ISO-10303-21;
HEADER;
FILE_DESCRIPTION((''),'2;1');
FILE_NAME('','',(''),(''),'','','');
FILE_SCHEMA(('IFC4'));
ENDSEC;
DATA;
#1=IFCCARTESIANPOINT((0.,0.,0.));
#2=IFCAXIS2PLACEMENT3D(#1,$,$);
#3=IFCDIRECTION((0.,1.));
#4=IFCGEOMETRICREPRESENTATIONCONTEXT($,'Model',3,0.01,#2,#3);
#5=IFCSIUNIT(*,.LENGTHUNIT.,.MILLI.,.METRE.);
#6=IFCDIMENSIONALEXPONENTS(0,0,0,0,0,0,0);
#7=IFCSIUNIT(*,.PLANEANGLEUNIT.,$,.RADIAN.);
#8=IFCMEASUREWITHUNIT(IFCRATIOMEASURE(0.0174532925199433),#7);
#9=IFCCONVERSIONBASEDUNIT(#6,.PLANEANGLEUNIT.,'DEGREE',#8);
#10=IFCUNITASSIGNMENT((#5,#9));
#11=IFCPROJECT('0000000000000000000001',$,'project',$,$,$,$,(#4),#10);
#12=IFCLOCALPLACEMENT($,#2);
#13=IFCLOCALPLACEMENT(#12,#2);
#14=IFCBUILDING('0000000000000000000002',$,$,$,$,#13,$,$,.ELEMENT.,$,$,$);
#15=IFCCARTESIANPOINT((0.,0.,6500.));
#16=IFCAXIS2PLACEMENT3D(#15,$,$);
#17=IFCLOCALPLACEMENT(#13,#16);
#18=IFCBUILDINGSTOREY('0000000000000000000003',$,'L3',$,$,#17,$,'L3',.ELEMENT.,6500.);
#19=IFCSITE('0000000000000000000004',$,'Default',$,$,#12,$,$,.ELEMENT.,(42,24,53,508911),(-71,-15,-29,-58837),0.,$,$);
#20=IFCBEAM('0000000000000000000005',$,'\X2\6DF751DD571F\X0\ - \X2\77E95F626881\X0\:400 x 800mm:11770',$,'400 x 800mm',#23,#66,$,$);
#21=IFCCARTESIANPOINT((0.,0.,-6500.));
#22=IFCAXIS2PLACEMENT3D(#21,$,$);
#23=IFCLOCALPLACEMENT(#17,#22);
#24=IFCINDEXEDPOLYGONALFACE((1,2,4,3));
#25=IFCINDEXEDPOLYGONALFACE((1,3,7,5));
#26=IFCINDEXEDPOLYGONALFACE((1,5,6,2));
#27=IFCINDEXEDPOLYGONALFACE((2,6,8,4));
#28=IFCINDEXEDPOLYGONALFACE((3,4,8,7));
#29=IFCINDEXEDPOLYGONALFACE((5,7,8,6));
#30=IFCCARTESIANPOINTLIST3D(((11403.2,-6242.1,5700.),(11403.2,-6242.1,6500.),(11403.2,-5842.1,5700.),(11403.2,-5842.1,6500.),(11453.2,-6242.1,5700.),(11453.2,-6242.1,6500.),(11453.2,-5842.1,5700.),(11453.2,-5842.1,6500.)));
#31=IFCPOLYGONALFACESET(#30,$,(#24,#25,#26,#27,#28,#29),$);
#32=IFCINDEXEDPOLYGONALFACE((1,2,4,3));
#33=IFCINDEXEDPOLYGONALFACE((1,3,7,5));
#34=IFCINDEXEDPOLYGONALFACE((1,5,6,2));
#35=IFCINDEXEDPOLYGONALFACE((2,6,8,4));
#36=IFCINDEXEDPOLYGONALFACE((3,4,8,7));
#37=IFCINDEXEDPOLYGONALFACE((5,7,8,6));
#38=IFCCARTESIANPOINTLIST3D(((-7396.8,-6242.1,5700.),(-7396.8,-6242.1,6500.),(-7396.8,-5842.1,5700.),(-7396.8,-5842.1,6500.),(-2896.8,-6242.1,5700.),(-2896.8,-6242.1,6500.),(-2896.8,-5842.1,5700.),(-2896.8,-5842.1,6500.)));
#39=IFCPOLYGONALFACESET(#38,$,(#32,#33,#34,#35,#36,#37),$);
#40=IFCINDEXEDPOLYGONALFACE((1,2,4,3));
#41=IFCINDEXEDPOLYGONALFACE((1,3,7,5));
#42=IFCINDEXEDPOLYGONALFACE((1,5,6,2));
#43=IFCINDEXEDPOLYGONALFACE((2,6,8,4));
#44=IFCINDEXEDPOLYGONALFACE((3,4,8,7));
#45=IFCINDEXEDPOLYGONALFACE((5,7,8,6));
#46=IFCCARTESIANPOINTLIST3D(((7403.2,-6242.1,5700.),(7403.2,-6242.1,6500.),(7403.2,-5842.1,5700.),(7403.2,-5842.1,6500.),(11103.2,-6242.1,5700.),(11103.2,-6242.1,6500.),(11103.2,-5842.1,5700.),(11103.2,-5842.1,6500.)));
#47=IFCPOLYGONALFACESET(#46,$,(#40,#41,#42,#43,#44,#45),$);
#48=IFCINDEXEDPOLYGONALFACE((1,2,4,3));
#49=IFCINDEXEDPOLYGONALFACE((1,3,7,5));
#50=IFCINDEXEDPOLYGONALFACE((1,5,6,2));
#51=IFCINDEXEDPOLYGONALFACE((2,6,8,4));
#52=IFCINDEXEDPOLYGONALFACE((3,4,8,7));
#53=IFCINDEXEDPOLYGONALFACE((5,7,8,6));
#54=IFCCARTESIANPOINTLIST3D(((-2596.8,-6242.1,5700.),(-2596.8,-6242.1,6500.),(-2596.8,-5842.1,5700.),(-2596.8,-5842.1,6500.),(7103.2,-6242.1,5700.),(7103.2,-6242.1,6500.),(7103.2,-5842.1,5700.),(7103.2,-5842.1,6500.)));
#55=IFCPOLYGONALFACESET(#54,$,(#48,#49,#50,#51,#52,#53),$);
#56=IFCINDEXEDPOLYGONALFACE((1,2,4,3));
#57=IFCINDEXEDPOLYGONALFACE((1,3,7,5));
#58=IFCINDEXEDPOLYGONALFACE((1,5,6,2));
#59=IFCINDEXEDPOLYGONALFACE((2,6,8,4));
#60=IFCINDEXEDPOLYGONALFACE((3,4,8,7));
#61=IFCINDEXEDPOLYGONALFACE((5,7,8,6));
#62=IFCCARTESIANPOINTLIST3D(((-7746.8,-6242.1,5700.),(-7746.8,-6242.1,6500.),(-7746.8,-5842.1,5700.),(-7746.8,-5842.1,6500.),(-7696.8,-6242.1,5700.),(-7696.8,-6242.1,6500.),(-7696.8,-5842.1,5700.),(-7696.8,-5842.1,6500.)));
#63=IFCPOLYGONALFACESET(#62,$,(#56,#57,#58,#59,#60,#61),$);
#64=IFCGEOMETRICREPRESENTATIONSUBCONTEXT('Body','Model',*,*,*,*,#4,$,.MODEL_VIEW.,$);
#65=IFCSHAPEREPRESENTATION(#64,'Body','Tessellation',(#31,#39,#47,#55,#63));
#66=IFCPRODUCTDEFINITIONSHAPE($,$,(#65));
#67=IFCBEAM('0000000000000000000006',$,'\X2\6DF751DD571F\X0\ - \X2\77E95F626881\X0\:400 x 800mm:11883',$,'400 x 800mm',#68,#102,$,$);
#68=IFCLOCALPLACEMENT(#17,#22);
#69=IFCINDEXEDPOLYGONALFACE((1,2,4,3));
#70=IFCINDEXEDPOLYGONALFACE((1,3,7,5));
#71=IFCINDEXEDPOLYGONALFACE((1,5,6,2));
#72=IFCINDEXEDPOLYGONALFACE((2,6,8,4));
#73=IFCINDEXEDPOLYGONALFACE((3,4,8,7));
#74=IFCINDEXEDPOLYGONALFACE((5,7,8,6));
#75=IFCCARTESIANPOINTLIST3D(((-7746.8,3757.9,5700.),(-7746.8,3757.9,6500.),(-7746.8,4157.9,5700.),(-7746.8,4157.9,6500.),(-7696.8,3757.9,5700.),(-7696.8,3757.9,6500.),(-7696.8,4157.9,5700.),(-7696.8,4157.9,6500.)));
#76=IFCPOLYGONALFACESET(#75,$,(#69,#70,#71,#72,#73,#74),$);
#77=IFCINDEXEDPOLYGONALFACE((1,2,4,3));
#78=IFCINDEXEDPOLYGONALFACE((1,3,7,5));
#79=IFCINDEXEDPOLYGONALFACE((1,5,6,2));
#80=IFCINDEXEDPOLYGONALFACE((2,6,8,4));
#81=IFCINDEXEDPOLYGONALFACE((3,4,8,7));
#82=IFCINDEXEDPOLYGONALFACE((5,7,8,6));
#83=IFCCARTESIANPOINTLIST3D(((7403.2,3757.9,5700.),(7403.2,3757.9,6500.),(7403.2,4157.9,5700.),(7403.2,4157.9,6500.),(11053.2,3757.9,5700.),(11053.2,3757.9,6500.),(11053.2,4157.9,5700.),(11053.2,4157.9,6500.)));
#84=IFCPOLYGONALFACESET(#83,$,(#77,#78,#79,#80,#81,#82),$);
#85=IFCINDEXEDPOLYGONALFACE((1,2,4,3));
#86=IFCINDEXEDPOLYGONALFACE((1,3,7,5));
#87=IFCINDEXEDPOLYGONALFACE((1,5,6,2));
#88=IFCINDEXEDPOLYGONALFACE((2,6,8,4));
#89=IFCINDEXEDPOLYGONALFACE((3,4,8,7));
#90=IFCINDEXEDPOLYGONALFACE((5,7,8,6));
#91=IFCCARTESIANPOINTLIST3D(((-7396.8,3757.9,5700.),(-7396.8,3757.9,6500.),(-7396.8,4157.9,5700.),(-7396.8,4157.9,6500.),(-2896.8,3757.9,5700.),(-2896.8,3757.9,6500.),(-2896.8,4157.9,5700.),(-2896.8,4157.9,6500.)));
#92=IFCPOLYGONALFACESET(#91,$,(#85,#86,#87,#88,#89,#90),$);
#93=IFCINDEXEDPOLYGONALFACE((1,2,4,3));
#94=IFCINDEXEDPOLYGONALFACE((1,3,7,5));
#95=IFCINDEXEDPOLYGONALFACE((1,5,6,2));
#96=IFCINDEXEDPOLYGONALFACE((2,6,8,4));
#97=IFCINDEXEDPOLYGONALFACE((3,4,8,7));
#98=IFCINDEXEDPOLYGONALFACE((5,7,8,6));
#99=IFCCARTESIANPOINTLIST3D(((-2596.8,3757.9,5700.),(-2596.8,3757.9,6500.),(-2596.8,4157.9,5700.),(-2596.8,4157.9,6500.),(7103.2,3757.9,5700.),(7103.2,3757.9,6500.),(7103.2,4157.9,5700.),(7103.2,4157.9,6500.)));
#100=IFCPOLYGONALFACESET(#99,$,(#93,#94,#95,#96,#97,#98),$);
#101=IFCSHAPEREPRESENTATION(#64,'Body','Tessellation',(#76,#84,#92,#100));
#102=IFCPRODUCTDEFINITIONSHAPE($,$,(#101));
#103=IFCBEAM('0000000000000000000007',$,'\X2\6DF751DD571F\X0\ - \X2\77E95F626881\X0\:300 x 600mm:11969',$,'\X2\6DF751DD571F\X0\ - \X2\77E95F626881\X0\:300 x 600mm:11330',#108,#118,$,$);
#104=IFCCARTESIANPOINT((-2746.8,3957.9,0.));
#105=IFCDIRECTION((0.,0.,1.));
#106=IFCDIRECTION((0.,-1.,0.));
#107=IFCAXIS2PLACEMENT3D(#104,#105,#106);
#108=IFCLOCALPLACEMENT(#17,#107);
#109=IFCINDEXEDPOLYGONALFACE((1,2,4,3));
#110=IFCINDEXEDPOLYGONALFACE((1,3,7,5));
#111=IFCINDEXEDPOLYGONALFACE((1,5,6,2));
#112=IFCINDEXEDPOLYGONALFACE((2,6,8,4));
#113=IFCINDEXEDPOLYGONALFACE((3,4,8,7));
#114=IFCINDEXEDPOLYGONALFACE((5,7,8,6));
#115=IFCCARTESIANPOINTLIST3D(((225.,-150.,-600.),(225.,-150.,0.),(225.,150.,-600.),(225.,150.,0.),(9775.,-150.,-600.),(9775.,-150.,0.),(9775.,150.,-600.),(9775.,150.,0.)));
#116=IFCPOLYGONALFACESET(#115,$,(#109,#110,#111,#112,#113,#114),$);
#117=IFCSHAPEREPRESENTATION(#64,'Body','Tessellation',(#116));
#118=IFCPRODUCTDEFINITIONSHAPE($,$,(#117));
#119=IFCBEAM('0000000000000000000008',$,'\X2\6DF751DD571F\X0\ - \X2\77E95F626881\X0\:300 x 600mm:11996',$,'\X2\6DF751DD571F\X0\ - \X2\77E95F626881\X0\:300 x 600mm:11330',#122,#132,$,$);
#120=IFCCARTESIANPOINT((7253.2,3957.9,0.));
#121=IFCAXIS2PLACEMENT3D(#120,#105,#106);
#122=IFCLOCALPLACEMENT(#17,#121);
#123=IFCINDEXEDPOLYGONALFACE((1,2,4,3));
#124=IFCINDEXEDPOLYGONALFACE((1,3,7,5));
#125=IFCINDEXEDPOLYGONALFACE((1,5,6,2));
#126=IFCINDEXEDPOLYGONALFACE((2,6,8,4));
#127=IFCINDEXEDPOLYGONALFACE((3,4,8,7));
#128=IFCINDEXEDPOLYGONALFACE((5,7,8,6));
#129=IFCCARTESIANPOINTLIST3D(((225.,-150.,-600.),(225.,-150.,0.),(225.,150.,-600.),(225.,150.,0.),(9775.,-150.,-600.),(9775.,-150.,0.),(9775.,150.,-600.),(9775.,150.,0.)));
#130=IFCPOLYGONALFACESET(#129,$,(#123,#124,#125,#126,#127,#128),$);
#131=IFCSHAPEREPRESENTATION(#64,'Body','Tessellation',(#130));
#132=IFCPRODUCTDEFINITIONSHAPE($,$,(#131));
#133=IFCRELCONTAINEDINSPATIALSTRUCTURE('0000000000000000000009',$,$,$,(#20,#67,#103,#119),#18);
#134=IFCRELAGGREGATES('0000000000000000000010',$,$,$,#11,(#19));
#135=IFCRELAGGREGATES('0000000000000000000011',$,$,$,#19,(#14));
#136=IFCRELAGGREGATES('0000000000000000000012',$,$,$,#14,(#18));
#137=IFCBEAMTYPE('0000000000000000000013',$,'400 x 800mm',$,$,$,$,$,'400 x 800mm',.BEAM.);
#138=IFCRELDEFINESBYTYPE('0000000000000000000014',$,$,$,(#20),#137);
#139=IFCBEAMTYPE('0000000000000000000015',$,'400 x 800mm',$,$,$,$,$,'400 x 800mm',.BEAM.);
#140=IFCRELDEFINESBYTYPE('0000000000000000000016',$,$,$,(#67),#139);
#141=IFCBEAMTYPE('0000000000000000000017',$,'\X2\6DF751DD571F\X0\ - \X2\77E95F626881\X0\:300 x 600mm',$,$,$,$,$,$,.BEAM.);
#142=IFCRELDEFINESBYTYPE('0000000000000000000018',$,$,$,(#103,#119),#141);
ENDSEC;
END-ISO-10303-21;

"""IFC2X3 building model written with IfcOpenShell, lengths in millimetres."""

from ifc_helpers import new_model, entity, si_unit, converted_unit, direction, frame, frame_2d, origin, origin_2d_with_axis, place, context, subcontext, project, spatial, rectangle, extrude, source, transform, mapped, type_object, type_shapes, element, save


model = new_model("IFC2X3")

# Units and contexts
model_context = context("Model", 3, precision=0.01, world=origin(), true_north=direction((0.0, 1.0)))
body_context = subcontext(model_context, "Body", "Model", "MODEL_VIEW")
ifc_project = project(units=[si_unit("LENGTHUNIT", "METRE", prefix="MILLI"), converted_unit("PLANEANGLEUNIT", "DEGREE", entity("IfcRatioMeasure", 0.0174532925199433), si_unit("PLANEANGLEUNIT", "RADIAN"), dimensions=[0, 0, 0, 0, 0, 0, 0])], contexts=[model_context])

# Site, building, storey
site_placement = place(None, origin())
site = spatial("IfcSite", under=ifc_project, at=site_placement, Name="Default", CompositionType="ELEMENT", RefLatitude=(42, 24, 53, 508911), RefLongitude=(-71, -15, -29, -58837), RefElevation=0.0)
building_placement = place(site_placement, origin())
building = spatial("IfcBuilding", under=site, at=building_placement, CompositionType="ELEMENT")
storey_placement = place(building_placement, frame((0.0, 0.0, 6500.0)))
storey = spatial("IfcBuildingStorey", under=building, at=storey_placement, Name="L3", LongName="L3", CompositionType="ELEMENT", Elevation=6500.0)

# Beams
beam_type_1 = type_object("IfcBeamType", Name="400 x 800mm", ElementType="400 x 800mm", PredefinedType="BEAM")
shared_shape_1 = source(origin(), body_context, "Body", "SweptSolid", [
    extrude(rectangle(XDim=50.0, YDim=400.0, at=frame_2d((0.0, 0.0), x_axis=(1.0, 0.0))), frame((11428.2, -6042.1, 5700.0), z_axis=(0.0, 0.0, 1.0), x_axis=(-1.0, 0.0, 0.0)), (0.0, 0.0, 1.0), 800.0),
    extrude(rectangle(XDim=4500.0, YDim=400.0, at=frame_2d((440.0, -40.0), x_axis=(1.0, 0.0))), frame((-5586.8, -6002.1, 5700.0)), (0.0, 0.0, 1.0), 800.0),
    extrude(rectangle(XDim=3700.0, YDim=400.0, at=frame_2d((360.0, 40.0), x_axis=(1.0, 0.0))), frame((9613.2, -6002.1, 5700.0), z_axis=(0.0, 0.0, 1.0), x_axis=(-1.0, 0.0, 0.0)), (0.0, 0.0, 1.0), 800.0),
    extrude(rectangle(XDim=9700.0, YDim=400.0, at=origin_2d_with_axis()), frame((2253.2, -6042.1, 5700.0)), (0.0, 0.0, 1.0), 800.0),
    extrude(rectangle(XDim=50.0, YDim=400.0, at=frame_2d((0.0, 0.0), x_axis=(1.0, 0.0))), frame((-7721.8, -6042.1, 5700.0)), (0.0, 0.0, 1.0), 800.0),
])
type_shapes(beam_type_1, [shared_shape_1])
beam_1_placement = place(storey_placement, frame((0.0, 0.0, -6500.0)))
element("IfcBeam", 1, at=beam_1_placement, inside=storey, type_object=beam_type_1, Name="混凝土 - 矩形梁:400 x 800mm:11770", ObjectType="400 x 800mm", context=body_context, shape_type="MappedRepresentation", body=[
    mapped(shared_shape_1, transform((0.0, 0.0, 0.0), scale=1.0)),
])
beam_type_2 = type_object("IfcBeamType", Name="400 x 800mm", ElementType="400 x 800mm", PredefinedType="BEAM")
shared_shape_2 = source(origin(), body_context, "Body", "SweptSolid", [
    extrude(rectangle(XDim=50.0, YDim=400.0, at=frame_2d((0.0, 0.0), x_axis=(1.0, 0.0))), frame((-7721.8, 3957.9, 5700.0)), (0.0, 0.0, 1.0), 800.0),
    extrude(rectangle(XDim=3650.0, YDim=400.0, at=frame_2d((0.0, 0.0), x_axis=(1.0, 0.0))), frame((9228.2, 3957.9, 5700.0), z_axis=(0.0, 0.0, 1.0), x_axis=(-1.0, 0.0, 0.0)), (0.0, 0.0, 1.0), 800.0),
    extrude(rectangle(XDim=4500.0, YDim=400.0, at=frame_2d((440.0, 40.0), x_axis=(1.0, 0.0))), frame((-5586.8, 3917.9, 5700.0)), (0.0, 0.0, 1.0), 800.0),
    extrude(rectangle(XDim=9700.0, YDim=400.0, at=frame_2d((0.0, 0.0), x_axis=(1.0, 0.0))), frame((2253.2, 3957.9, 5700.0), z_axis=(0.0, 0.0, 1.0), x_axis=(-1.0, 0.0, 0.0)), (0.0, 0.0, 1.0), 800.0),
])
type_shapes(beam_type_2, [shared_shape_2])
beam_2_placement = place(storey_placement, frame((0.0, 0.0, -6500.0)))
element("IfcBeam", 2, at=beam_2_placement, inside=storey, type_object=beam_type_2, Name="混凝土 - 矩形梁:400 x 800mm:11883", ObjectType="400 x 800mm", context=body_context, shape_type="MappedRepresentation", body=[
    mapped(shared_shape_2, transform((0.0, 0.0, 0.0), scale=1.0)),
])
beam_type_3 = type_object("IfcBeamType", Name="混凝土 - 矩形梁:300 x 600mm", PredefinedType="BEAM")
beam_3_placement = place(storey_placement, frame((-2746.8, 3957.9, 0.0), z_axis=(0.0, 0.0, 1.0), x_axis=(0.0, -1.0, 0.0)))
element("IfcBeam", 3, at=beam_3_placement, inside=storey, type_object=beam_type_3, Name="混凝土 - 矩形梁:300 x 600mm:11969", ObjectType="混凝土 - 矩形梁:300 x 600mm:11330", context=body_context, shape_type="SweptSolid", body=[
    extrude(rectangle(XDim=600.0, YDim=300.0, at=frame_2d((0.0, 0.0), x_axis=(1.0, 0.0))), frame((225.0, 0.0, -300.0), z_axis=(1.0, 0.0, 0.0), x_axis=(0.0, 0.0, -1.0)), (0.0, 0.0, 1.0), 9550.0),
])
beam_4_placement = place(storey_placement, frame((7253.2, 3957.9, 0.0), z_axis=(0.0, 0.0, 1.0), x_axis=(0.0, -1.0, 0.0)))
element("IfcBeam", 4, at=beam_4_placement, inside=storey, type_object=beam_type_3, Name="混凝土 - 矩形梁:300 x 600mm:11996", ObjectType="混凝土 - 矩形梁:300 x 600mm:11330", context=body_context, shape_type="SweptSolid", body=[
    extrude(rectangle(XDim=600.0, YDim=300.0, at=frame_2d((0.0, 0.0), x_axis=(1.0, 0.0))), frame((225.0, 0.0, -300.0), z_axis=(1.0, 0.0, 0.0), x_axis=(0.0, 0.0, -1.0)), (0.0, 0.0, 1.0), 9550.0),
])

save(model, "model.ifc")
